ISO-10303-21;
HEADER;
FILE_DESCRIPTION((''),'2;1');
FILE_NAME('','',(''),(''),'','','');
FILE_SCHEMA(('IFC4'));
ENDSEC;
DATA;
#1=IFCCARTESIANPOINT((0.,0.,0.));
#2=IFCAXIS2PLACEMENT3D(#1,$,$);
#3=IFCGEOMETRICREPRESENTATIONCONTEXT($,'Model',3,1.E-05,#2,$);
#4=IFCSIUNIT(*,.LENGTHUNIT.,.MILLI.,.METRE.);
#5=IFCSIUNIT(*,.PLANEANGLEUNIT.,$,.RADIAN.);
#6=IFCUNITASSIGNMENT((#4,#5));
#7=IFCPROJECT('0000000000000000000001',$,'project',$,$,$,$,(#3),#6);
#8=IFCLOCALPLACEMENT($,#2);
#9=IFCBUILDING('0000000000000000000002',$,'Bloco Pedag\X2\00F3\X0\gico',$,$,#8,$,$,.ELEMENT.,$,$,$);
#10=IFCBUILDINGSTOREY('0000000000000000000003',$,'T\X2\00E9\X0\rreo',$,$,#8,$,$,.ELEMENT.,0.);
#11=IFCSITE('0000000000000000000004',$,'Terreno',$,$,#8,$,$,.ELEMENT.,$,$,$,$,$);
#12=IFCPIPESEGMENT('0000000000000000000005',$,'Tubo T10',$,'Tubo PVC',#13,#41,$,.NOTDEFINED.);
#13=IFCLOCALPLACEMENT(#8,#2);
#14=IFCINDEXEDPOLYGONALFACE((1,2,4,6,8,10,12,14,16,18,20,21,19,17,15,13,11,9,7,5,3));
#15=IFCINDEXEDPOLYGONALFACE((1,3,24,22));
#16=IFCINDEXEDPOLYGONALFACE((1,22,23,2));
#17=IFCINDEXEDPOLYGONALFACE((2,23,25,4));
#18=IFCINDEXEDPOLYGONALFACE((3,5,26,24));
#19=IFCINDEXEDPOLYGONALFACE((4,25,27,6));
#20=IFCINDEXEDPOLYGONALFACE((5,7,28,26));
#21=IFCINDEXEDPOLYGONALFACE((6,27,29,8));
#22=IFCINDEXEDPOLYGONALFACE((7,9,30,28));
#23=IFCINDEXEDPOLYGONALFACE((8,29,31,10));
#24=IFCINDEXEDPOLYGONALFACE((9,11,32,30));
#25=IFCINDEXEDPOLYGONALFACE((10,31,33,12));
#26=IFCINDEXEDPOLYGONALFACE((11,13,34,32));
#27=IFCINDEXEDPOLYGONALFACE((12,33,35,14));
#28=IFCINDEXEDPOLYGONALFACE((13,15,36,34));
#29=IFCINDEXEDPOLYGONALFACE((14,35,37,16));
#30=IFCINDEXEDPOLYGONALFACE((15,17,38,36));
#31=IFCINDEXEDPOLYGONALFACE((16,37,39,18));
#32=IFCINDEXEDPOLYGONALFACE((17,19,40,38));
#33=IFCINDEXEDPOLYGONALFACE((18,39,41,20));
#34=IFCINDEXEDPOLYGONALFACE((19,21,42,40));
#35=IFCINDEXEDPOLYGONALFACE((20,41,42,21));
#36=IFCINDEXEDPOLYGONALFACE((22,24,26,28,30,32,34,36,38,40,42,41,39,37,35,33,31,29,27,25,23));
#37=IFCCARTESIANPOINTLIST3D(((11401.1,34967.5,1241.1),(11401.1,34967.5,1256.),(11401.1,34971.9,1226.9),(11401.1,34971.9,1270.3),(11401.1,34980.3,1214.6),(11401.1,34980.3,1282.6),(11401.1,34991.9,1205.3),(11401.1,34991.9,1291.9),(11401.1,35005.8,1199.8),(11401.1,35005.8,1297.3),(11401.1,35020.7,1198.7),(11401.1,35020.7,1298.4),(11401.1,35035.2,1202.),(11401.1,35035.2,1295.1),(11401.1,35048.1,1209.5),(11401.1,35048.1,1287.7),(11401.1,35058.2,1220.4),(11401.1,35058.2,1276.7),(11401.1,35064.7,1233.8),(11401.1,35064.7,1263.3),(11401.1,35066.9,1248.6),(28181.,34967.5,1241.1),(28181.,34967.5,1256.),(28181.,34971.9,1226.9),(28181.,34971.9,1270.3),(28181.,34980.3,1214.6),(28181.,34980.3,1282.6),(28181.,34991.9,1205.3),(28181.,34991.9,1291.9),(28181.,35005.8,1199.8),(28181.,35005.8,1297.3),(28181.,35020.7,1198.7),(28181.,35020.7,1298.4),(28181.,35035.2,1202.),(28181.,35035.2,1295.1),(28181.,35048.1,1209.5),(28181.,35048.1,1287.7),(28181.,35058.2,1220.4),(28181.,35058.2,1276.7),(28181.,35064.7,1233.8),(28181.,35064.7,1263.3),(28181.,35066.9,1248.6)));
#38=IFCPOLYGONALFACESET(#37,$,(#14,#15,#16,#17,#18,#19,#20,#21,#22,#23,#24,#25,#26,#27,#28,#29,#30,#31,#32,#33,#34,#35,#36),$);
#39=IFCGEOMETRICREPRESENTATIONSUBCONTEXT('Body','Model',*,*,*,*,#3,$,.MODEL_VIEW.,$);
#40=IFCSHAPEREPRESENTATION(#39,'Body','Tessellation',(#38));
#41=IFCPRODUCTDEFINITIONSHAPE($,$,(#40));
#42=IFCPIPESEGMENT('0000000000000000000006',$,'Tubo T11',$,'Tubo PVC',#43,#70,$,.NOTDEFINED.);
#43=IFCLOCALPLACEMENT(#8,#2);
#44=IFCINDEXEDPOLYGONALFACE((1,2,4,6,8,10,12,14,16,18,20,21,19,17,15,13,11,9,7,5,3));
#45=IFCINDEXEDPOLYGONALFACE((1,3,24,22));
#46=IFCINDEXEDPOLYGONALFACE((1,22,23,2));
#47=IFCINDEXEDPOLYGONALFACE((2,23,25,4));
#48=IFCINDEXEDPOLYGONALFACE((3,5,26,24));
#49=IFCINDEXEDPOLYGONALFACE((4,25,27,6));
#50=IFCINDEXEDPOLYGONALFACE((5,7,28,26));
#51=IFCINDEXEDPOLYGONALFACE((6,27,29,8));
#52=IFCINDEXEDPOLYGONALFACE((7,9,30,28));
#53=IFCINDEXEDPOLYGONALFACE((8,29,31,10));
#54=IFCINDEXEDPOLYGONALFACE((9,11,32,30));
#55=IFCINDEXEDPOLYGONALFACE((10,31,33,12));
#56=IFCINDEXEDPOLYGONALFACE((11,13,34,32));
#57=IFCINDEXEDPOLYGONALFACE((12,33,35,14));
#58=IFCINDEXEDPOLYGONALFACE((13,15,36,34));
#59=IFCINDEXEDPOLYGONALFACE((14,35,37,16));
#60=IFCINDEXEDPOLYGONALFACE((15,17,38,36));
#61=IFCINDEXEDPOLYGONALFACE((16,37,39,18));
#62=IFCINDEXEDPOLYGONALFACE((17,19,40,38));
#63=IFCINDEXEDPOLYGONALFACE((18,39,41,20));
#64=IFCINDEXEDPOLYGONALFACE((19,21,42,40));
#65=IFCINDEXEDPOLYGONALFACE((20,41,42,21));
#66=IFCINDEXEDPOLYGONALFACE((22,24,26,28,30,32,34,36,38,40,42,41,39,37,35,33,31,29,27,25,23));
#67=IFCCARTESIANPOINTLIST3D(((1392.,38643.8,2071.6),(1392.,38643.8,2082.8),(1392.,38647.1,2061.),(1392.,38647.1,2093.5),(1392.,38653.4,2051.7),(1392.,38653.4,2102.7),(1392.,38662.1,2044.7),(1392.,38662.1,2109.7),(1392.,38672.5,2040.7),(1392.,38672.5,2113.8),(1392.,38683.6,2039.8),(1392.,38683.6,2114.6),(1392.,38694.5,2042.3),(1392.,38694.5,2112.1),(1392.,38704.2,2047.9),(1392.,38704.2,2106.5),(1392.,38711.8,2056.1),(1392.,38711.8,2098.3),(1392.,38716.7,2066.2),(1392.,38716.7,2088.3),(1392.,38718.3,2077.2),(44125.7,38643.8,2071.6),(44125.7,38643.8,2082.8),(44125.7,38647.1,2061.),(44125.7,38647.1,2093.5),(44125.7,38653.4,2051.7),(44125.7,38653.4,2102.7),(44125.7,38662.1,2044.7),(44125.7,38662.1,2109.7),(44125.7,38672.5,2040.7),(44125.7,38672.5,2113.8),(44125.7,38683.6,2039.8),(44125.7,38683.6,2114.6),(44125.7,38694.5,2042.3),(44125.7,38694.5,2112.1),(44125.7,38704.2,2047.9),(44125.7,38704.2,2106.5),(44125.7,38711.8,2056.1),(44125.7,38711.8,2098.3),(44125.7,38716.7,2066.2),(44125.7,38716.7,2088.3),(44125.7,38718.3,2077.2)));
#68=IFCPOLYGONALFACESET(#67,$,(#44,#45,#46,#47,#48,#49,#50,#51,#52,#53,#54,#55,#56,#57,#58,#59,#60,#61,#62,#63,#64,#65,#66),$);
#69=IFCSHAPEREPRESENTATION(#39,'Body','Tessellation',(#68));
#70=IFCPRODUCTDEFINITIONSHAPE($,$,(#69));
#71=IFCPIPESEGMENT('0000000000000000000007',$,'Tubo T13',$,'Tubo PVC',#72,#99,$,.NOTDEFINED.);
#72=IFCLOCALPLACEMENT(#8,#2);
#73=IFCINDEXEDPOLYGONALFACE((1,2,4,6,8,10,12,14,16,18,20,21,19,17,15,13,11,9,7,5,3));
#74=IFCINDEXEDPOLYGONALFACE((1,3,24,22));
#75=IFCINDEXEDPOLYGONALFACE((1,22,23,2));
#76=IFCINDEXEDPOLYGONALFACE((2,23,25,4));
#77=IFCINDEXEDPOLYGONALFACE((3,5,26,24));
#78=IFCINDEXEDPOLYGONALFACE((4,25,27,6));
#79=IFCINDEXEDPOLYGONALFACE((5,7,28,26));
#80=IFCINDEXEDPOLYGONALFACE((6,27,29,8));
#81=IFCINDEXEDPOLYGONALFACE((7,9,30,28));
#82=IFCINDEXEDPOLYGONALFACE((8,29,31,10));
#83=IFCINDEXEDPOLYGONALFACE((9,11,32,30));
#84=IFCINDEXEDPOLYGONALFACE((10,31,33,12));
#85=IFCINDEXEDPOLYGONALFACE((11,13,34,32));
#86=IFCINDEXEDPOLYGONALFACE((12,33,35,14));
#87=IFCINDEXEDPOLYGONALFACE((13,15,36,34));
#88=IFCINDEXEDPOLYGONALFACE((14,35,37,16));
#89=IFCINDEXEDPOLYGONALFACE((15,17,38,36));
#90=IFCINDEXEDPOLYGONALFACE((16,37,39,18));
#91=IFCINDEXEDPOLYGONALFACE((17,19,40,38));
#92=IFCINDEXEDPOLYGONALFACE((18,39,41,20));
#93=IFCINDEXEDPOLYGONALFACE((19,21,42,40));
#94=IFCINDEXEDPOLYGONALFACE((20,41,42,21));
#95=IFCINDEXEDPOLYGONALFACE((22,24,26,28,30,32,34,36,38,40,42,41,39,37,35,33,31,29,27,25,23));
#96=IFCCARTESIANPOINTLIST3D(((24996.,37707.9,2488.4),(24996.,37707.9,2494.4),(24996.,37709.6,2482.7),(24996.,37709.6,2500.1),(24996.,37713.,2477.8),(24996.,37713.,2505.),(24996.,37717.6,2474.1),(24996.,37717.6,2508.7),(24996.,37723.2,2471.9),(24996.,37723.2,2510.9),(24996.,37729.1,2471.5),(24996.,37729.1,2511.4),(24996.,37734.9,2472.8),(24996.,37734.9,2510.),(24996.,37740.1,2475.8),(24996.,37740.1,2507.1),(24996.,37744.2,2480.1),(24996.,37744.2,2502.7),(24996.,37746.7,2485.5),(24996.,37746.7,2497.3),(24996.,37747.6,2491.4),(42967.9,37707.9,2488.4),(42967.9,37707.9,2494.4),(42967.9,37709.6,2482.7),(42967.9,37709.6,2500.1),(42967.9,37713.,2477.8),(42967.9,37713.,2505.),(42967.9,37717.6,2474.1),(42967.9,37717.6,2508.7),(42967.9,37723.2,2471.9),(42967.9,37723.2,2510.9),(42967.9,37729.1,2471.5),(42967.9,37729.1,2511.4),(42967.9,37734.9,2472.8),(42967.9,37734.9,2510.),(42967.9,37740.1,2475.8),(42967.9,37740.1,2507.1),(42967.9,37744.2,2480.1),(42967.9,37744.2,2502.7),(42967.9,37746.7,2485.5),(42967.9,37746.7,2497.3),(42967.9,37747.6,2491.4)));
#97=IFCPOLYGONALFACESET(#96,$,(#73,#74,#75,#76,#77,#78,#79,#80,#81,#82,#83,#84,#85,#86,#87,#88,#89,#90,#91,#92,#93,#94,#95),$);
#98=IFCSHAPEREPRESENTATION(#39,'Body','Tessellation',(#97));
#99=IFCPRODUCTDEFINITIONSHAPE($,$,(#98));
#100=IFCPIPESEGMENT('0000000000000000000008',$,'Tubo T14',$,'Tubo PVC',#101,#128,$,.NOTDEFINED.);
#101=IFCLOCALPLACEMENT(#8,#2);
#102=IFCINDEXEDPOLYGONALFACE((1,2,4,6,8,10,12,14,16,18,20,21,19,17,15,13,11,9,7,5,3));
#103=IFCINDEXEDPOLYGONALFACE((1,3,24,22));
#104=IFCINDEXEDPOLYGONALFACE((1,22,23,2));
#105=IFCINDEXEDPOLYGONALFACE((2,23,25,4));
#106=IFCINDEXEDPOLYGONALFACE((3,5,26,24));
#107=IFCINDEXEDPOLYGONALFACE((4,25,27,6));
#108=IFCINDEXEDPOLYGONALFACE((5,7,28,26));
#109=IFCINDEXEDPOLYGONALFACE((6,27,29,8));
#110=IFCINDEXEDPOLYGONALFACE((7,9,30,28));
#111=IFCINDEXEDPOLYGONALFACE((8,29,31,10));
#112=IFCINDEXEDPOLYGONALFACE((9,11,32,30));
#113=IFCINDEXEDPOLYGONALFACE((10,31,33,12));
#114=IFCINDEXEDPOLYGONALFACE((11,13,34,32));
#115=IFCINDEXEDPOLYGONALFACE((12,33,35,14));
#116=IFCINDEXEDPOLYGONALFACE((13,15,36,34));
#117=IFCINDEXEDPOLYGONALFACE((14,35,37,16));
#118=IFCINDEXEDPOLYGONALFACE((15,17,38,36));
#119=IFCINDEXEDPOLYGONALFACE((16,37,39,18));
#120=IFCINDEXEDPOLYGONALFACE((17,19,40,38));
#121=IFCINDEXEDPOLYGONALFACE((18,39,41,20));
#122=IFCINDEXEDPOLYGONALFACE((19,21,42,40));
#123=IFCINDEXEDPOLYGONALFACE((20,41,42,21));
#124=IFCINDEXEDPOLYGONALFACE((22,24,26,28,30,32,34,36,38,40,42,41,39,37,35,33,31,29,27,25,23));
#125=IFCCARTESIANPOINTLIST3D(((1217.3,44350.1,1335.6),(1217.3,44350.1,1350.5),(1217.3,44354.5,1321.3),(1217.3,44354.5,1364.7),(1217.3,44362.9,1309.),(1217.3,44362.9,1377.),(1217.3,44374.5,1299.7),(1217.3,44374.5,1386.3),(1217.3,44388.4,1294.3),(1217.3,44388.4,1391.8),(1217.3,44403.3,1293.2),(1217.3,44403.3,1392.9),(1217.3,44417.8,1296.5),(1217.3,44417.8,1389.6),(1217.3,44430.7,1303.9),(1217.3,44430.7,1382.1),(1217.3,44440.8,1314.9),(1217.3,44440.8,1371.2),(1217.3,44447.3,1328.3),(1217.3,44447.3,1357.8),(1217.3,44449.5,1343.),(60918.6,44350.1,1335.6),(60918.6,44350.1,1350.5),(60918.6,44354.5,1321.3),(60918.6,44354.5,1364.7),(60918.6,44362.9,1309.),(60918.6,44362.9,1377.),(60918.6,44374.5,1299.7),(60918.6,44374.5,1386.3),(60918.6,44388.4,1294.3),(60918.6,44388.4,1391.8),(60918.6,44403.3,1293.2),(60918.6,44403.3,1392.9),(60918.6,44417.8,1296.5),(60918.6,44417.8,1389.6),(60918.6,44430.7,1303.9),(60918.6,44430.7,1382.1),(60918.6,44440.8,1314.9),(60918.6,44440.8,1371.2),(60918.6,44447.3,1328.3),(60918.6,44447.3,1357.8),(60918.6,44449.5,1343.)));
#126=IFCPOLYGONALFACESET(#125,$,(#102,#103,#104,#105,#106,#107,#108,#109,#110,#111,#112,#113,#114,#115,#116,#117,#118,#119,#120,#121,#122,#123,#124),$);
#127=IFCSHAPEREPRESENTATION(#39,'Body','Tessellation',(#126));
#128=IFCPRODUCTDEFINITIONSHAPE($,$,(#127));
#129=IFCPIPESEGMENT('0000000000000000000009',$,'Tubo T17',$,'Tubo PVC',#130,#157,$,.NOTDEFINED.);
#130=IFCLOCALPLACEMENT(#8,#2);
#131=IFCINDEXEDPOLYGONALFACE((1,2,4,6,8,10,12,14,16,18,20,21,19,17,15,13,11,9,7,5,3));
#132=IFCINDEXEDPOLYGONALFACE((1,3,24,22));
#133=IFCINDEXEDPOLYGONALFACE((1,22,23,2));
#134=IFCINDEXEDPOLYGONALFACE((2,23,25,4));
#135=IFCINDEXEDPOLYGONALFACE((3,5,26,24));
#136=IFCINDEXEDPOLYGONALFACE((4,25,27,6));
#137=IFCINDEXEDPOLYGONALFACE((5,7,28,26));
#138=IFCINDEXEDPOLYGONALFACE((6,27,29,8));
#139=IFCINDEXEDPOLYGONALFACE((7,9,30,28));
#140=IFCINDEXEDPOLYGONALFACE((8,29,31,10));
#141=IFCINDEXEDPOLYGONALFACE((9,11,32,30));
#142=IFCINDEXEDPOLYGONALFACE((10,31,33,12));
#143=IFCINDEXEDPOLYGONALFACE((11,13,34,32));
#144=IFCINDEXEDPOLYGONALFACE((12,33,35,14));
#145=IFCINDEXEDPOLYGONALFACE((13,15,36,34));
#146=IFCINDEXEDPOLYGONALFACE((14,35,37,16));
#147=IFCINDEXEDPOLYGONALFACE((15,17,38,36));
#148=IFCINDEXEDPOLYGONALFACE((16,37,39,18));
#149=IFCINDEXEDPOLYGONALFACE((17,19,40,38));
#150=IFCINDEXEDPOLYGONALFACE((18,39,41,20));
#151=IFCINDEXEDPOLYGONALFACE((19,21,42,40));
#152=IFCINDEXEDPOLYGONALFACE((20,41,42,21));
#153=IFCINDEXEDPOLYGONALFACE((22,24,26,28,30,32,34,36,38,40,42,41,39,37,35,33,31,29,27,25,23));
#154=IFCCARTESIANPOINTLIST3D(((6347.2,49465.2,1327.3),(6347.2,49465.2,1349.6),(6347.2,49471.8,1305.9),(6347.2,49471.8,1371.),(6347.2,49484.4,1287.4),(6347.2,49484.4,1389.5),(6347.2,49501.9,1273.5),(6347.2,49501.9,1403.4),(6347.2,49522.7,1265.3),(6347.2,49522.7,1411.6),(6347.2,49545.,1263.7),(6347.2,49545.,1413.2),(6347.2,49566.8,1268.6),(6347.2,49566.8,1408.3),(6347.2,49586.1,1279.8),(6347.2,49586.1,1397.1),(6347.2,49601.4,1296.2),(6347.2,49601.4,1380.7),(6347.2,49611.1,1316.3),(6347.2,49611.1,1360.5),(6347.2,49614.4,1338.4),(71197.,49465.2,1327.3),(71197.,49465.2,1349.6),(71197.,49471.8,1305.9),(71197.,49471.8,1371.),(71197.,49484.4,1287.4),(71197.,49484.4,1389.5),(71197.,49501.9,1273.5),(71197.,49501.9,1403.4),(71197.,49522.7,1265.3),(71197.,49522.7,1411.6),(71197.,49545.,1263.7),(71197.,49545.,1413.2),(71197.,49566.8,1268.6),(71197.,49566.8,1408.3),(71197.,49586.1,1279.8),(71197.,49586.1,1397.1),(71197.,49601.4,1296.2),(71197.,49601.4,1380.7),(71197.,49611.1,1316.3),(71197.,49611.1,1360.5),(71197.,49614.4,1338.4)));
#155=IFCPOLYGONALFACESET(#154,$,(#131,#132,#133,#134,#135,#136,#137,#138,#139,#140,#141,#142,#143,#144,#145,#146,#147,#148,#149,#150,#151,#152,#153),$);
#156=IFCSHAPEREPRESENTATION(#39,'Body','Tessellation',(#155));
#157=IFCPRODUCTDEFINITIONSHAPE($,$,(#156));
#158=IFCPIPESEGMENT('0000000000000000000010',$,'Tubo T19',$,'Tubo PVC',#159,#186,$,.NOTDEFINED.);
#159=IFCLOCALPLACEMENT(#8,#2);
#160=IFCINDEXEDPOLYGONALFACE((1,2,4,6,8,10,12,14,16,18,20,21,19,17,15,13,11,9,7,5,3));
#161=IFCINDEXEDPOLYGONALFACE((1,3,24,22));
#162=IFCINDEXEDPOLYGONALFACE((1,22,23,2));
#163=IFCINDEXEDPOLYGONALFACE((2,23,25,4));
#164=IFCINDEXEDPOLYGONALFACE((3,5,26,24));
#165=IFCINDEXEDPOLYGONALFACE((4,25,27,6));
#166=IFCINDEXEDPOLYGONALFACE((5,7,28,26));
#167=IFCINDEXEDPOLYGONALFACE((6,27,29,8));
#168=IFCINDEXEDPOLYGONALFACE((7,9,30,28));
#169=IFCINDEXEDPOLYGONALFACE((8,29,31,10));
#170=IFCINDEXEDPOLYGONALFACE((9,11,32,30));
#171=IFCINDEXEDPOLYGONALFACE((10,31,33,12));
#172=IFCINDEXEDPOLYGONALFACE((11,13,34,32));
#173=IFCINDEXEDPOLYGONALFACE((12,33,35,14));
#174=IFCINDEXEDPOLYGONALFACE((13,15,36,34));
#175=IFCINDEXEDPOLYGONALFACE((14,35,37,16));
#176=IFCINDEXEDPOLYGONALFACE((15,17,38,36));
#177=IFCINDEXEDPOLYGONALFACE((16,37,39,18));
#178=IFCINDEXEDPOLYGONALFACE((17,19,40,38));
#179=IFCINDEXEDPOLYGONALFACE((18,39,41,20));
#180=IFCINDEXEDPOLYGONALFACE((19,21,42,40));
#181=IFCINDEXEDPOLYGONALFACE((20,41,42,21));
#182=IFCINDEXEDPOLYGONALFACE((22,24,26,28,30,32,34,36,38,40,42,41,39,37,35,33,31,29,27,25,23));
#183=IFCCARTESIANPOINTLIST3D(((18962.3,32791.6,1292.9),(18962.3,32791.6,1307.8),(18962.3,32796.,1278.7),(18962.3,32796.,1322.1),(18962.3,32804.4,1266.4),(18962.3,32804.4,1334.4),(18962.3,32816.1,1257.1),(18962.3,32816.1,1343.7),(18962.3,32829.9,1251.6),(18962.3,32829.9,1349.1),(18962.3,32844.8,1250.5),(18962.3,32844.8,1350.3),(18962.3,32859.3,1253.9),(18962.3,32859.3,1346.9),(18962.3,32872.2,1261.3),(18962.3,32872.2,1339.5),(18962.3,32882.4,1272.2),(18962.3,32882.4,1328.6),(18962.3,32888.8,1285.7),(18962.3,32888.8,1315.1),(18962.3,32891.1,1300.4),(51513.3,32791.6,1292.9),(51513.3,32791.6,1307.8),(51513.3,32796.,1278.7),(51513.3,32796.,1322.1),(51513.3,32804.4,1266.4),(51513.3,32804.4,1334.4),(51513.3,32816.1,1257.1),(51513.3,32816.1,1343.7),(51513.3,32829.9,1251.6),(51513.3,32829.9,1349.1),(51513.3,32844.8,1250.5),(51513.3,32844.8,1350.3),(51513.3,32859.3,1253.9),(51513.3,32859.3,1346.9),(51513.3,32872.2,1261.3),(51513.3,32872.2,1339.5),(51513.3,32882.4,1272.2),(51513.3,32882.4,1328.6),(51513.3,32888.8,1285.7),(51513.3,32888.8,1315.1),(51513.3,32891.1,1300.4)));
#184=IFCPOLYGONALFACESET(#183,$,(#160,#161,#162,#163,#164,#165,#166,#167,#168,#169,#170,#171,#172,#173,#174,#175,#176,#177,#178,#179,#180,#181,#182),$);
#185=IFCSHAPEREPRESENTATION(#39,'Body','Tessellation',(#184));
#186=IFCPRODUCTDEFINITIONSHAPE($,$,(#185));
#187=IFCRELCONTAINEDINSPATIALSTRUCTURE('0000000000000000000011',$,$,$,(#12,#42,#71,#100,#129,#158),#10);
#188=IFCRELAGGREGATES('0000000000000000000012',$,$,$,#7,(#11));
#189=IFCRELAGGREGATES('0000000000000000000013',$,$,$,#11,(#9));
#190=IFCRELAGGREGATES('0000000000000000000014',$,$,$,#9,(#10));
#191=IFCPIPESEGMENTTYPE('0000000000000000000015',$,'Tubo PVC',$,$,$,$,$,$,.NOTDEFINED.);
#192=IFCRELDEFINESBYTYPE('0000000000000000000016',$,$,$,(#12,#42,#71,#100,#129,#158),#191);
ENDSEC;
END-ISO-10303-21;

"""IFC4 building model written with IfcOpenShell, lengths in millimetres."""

from ifc_helpers import new_model, si_unit, frame, origin, origin_2d, place, context, subcontext, project, spatial, circle, extrude, type_object, element, save


model = new_model("IFC4")

# Units and contexts
model_context = context("Model", 3, precision=1e-05, world=origin())
body_context = subcontext(model_context, "Body", "Model", "MODEL_VIEW")
ifc_project = project(units=[si_unit("LENGTHUNIT", "METRE", prefix="MILLI"), si_unit("PLANEANGLEUNIT", "RADIAN")], contexts=[model_context])

# Site, building, storey
placement = place(None, origin())
site = spatial("IfcSite", under=ifc_project, at=placement, Name="Terreno", CompositionType="ELEMENT")
building = spatial("IfcBuilding", under=site, at=placement, Name="Bloco Pedagógico", CompositionType="ELEMENT")
storey = spatial("IfcBuildingStorey", under=building, at=placement, Name="Térreo", CompositionType="ELEMENT", Elevation=0.0)

# Pipe segments
pipe_segment_type = type_object("IfcPipeSegmentType", Name="Tubo PVC", PredefinedType="NOTDEFINED")
pipe_segment_1_placement = place(None, frame((11401.1, 35016.9, 1248.6), z_axis=(1.0, 0.0, 0.0), x_axis=(0.0, 1.0, 0.0)))
element("IfcPipeSegment", 1, at=pipe_segment_1_placement, inside=storey, type_object=pipe_segment_type, Name="Tubo T10", ObjectType="Tubo PVC", PredefinedType="NOTDEFINED", context=body_context, shape_type="SweptSolid", body=[
    extrude(circle(Radius=50.0, at=origin_2d()), None, (0.0, 0.0, 1.0), 16779.9),
])
pipe_segment_2_placement = place(None, frame((1392.0, 38680.8, 2077.2), z_axis=(1.0, 0.0, 0.0), x_axis=(0.0, 1.0, 0.0)))
element("IfcPipeSegment", 2, at=pipe_segment_2_placement, inside=storey, type_object=pipe_segment_type, Name="Tubo T11", ObjectType="Tubo PVC", PredefinedType="NOTDEFINED", context=body_context, shape_type="SweptSolid", body=[
    extrude(circle(Radius=37.5, at=origin_2d()), None, (0.0, 0.0, 1.0), 42733.7),
])
pipe_segment_3_placement = place(None, frame((24996.0, 37727.6, 2491.4), z_axis=(1.0, 0.0, 0.0), x_axis=(0.0, 1.0, 0.0)))
element("IfcPipeSegment", 3, at=pipe_segment_3_placement, inside=storey, type_object=pipe_segment_type, Name="Tubo T13", ObjectType="Tubo PVC", PredefinedType="NOTDEFINED", context=body_context, shape_type="SweptSolid", body=[
    extrude(circle(Radius=20.0, at=origin_2d()), None, (0.0, 0.0, 1.0), 17971.9),
])
pipe_segment_4_placement = place(None, frame((1217.3, 44399.5, 1343.0), z_axis=(1.0, 0.0, 0.0), x_axis=(0.0, 1.0, 0.0)))
element("IfcPipeSegment", 4, at=pipe_segment_4_placement, inside=storey, type_object=pipe_segment_type, Name="Tubo T14", ObjectType="Tubo PVC", PredefinedType="NOTDEFINED", context=body_context, shape_type="SweptSolid", body=[
    extrude(circle(Radius=50.0, at=origin_2d()), None, (0.0, 0.0, 1.0), 59701.3),
])
pipe_segment_5_placement = place(None, frame((6347.2, 49539.4, 1338.4), z_axis=(1.0, 0.0, 0.0), x_axis=(0.0, 1.0, 0.0)))
element("IfcPipeSegment", 5, at=pipe_segment_5_placement, inside=storey, type_object=pipe_segment_type, Name="Tubo T17", ObjectType="Tubo PVC", PredefinedType="NOTDEFINED", context=body_context, shape_type="SweptSolid", body=[
    extrude(circle(Radius=75.0, at=origin_2d()), None, (0.0, 0.0, 1.0), 64849.8),
])
pipe_segment_6_placement = place(None, frame((18962.3, 32841.1, 1300.4), z_axis=(1.0, 0.0, 0.0), x_axis=(0.0, 1.0, 0.0)))
element("IfcPipeSegment", 6, at=pipe_segment_6_placement, inside=storey, type_object=pipe_segment_type, Name="Tubo T19", ObjectType="Tubo PVC", PredefinedType="NOTDEFINED", context=body_context, shape_type="SweptSolid", body=[
    extrude(circle(Radius=50.0, at=origin_2d()), None, (0.0, 0.0, 1.0), 32551.0),
])

save(model, "model.ifc")
